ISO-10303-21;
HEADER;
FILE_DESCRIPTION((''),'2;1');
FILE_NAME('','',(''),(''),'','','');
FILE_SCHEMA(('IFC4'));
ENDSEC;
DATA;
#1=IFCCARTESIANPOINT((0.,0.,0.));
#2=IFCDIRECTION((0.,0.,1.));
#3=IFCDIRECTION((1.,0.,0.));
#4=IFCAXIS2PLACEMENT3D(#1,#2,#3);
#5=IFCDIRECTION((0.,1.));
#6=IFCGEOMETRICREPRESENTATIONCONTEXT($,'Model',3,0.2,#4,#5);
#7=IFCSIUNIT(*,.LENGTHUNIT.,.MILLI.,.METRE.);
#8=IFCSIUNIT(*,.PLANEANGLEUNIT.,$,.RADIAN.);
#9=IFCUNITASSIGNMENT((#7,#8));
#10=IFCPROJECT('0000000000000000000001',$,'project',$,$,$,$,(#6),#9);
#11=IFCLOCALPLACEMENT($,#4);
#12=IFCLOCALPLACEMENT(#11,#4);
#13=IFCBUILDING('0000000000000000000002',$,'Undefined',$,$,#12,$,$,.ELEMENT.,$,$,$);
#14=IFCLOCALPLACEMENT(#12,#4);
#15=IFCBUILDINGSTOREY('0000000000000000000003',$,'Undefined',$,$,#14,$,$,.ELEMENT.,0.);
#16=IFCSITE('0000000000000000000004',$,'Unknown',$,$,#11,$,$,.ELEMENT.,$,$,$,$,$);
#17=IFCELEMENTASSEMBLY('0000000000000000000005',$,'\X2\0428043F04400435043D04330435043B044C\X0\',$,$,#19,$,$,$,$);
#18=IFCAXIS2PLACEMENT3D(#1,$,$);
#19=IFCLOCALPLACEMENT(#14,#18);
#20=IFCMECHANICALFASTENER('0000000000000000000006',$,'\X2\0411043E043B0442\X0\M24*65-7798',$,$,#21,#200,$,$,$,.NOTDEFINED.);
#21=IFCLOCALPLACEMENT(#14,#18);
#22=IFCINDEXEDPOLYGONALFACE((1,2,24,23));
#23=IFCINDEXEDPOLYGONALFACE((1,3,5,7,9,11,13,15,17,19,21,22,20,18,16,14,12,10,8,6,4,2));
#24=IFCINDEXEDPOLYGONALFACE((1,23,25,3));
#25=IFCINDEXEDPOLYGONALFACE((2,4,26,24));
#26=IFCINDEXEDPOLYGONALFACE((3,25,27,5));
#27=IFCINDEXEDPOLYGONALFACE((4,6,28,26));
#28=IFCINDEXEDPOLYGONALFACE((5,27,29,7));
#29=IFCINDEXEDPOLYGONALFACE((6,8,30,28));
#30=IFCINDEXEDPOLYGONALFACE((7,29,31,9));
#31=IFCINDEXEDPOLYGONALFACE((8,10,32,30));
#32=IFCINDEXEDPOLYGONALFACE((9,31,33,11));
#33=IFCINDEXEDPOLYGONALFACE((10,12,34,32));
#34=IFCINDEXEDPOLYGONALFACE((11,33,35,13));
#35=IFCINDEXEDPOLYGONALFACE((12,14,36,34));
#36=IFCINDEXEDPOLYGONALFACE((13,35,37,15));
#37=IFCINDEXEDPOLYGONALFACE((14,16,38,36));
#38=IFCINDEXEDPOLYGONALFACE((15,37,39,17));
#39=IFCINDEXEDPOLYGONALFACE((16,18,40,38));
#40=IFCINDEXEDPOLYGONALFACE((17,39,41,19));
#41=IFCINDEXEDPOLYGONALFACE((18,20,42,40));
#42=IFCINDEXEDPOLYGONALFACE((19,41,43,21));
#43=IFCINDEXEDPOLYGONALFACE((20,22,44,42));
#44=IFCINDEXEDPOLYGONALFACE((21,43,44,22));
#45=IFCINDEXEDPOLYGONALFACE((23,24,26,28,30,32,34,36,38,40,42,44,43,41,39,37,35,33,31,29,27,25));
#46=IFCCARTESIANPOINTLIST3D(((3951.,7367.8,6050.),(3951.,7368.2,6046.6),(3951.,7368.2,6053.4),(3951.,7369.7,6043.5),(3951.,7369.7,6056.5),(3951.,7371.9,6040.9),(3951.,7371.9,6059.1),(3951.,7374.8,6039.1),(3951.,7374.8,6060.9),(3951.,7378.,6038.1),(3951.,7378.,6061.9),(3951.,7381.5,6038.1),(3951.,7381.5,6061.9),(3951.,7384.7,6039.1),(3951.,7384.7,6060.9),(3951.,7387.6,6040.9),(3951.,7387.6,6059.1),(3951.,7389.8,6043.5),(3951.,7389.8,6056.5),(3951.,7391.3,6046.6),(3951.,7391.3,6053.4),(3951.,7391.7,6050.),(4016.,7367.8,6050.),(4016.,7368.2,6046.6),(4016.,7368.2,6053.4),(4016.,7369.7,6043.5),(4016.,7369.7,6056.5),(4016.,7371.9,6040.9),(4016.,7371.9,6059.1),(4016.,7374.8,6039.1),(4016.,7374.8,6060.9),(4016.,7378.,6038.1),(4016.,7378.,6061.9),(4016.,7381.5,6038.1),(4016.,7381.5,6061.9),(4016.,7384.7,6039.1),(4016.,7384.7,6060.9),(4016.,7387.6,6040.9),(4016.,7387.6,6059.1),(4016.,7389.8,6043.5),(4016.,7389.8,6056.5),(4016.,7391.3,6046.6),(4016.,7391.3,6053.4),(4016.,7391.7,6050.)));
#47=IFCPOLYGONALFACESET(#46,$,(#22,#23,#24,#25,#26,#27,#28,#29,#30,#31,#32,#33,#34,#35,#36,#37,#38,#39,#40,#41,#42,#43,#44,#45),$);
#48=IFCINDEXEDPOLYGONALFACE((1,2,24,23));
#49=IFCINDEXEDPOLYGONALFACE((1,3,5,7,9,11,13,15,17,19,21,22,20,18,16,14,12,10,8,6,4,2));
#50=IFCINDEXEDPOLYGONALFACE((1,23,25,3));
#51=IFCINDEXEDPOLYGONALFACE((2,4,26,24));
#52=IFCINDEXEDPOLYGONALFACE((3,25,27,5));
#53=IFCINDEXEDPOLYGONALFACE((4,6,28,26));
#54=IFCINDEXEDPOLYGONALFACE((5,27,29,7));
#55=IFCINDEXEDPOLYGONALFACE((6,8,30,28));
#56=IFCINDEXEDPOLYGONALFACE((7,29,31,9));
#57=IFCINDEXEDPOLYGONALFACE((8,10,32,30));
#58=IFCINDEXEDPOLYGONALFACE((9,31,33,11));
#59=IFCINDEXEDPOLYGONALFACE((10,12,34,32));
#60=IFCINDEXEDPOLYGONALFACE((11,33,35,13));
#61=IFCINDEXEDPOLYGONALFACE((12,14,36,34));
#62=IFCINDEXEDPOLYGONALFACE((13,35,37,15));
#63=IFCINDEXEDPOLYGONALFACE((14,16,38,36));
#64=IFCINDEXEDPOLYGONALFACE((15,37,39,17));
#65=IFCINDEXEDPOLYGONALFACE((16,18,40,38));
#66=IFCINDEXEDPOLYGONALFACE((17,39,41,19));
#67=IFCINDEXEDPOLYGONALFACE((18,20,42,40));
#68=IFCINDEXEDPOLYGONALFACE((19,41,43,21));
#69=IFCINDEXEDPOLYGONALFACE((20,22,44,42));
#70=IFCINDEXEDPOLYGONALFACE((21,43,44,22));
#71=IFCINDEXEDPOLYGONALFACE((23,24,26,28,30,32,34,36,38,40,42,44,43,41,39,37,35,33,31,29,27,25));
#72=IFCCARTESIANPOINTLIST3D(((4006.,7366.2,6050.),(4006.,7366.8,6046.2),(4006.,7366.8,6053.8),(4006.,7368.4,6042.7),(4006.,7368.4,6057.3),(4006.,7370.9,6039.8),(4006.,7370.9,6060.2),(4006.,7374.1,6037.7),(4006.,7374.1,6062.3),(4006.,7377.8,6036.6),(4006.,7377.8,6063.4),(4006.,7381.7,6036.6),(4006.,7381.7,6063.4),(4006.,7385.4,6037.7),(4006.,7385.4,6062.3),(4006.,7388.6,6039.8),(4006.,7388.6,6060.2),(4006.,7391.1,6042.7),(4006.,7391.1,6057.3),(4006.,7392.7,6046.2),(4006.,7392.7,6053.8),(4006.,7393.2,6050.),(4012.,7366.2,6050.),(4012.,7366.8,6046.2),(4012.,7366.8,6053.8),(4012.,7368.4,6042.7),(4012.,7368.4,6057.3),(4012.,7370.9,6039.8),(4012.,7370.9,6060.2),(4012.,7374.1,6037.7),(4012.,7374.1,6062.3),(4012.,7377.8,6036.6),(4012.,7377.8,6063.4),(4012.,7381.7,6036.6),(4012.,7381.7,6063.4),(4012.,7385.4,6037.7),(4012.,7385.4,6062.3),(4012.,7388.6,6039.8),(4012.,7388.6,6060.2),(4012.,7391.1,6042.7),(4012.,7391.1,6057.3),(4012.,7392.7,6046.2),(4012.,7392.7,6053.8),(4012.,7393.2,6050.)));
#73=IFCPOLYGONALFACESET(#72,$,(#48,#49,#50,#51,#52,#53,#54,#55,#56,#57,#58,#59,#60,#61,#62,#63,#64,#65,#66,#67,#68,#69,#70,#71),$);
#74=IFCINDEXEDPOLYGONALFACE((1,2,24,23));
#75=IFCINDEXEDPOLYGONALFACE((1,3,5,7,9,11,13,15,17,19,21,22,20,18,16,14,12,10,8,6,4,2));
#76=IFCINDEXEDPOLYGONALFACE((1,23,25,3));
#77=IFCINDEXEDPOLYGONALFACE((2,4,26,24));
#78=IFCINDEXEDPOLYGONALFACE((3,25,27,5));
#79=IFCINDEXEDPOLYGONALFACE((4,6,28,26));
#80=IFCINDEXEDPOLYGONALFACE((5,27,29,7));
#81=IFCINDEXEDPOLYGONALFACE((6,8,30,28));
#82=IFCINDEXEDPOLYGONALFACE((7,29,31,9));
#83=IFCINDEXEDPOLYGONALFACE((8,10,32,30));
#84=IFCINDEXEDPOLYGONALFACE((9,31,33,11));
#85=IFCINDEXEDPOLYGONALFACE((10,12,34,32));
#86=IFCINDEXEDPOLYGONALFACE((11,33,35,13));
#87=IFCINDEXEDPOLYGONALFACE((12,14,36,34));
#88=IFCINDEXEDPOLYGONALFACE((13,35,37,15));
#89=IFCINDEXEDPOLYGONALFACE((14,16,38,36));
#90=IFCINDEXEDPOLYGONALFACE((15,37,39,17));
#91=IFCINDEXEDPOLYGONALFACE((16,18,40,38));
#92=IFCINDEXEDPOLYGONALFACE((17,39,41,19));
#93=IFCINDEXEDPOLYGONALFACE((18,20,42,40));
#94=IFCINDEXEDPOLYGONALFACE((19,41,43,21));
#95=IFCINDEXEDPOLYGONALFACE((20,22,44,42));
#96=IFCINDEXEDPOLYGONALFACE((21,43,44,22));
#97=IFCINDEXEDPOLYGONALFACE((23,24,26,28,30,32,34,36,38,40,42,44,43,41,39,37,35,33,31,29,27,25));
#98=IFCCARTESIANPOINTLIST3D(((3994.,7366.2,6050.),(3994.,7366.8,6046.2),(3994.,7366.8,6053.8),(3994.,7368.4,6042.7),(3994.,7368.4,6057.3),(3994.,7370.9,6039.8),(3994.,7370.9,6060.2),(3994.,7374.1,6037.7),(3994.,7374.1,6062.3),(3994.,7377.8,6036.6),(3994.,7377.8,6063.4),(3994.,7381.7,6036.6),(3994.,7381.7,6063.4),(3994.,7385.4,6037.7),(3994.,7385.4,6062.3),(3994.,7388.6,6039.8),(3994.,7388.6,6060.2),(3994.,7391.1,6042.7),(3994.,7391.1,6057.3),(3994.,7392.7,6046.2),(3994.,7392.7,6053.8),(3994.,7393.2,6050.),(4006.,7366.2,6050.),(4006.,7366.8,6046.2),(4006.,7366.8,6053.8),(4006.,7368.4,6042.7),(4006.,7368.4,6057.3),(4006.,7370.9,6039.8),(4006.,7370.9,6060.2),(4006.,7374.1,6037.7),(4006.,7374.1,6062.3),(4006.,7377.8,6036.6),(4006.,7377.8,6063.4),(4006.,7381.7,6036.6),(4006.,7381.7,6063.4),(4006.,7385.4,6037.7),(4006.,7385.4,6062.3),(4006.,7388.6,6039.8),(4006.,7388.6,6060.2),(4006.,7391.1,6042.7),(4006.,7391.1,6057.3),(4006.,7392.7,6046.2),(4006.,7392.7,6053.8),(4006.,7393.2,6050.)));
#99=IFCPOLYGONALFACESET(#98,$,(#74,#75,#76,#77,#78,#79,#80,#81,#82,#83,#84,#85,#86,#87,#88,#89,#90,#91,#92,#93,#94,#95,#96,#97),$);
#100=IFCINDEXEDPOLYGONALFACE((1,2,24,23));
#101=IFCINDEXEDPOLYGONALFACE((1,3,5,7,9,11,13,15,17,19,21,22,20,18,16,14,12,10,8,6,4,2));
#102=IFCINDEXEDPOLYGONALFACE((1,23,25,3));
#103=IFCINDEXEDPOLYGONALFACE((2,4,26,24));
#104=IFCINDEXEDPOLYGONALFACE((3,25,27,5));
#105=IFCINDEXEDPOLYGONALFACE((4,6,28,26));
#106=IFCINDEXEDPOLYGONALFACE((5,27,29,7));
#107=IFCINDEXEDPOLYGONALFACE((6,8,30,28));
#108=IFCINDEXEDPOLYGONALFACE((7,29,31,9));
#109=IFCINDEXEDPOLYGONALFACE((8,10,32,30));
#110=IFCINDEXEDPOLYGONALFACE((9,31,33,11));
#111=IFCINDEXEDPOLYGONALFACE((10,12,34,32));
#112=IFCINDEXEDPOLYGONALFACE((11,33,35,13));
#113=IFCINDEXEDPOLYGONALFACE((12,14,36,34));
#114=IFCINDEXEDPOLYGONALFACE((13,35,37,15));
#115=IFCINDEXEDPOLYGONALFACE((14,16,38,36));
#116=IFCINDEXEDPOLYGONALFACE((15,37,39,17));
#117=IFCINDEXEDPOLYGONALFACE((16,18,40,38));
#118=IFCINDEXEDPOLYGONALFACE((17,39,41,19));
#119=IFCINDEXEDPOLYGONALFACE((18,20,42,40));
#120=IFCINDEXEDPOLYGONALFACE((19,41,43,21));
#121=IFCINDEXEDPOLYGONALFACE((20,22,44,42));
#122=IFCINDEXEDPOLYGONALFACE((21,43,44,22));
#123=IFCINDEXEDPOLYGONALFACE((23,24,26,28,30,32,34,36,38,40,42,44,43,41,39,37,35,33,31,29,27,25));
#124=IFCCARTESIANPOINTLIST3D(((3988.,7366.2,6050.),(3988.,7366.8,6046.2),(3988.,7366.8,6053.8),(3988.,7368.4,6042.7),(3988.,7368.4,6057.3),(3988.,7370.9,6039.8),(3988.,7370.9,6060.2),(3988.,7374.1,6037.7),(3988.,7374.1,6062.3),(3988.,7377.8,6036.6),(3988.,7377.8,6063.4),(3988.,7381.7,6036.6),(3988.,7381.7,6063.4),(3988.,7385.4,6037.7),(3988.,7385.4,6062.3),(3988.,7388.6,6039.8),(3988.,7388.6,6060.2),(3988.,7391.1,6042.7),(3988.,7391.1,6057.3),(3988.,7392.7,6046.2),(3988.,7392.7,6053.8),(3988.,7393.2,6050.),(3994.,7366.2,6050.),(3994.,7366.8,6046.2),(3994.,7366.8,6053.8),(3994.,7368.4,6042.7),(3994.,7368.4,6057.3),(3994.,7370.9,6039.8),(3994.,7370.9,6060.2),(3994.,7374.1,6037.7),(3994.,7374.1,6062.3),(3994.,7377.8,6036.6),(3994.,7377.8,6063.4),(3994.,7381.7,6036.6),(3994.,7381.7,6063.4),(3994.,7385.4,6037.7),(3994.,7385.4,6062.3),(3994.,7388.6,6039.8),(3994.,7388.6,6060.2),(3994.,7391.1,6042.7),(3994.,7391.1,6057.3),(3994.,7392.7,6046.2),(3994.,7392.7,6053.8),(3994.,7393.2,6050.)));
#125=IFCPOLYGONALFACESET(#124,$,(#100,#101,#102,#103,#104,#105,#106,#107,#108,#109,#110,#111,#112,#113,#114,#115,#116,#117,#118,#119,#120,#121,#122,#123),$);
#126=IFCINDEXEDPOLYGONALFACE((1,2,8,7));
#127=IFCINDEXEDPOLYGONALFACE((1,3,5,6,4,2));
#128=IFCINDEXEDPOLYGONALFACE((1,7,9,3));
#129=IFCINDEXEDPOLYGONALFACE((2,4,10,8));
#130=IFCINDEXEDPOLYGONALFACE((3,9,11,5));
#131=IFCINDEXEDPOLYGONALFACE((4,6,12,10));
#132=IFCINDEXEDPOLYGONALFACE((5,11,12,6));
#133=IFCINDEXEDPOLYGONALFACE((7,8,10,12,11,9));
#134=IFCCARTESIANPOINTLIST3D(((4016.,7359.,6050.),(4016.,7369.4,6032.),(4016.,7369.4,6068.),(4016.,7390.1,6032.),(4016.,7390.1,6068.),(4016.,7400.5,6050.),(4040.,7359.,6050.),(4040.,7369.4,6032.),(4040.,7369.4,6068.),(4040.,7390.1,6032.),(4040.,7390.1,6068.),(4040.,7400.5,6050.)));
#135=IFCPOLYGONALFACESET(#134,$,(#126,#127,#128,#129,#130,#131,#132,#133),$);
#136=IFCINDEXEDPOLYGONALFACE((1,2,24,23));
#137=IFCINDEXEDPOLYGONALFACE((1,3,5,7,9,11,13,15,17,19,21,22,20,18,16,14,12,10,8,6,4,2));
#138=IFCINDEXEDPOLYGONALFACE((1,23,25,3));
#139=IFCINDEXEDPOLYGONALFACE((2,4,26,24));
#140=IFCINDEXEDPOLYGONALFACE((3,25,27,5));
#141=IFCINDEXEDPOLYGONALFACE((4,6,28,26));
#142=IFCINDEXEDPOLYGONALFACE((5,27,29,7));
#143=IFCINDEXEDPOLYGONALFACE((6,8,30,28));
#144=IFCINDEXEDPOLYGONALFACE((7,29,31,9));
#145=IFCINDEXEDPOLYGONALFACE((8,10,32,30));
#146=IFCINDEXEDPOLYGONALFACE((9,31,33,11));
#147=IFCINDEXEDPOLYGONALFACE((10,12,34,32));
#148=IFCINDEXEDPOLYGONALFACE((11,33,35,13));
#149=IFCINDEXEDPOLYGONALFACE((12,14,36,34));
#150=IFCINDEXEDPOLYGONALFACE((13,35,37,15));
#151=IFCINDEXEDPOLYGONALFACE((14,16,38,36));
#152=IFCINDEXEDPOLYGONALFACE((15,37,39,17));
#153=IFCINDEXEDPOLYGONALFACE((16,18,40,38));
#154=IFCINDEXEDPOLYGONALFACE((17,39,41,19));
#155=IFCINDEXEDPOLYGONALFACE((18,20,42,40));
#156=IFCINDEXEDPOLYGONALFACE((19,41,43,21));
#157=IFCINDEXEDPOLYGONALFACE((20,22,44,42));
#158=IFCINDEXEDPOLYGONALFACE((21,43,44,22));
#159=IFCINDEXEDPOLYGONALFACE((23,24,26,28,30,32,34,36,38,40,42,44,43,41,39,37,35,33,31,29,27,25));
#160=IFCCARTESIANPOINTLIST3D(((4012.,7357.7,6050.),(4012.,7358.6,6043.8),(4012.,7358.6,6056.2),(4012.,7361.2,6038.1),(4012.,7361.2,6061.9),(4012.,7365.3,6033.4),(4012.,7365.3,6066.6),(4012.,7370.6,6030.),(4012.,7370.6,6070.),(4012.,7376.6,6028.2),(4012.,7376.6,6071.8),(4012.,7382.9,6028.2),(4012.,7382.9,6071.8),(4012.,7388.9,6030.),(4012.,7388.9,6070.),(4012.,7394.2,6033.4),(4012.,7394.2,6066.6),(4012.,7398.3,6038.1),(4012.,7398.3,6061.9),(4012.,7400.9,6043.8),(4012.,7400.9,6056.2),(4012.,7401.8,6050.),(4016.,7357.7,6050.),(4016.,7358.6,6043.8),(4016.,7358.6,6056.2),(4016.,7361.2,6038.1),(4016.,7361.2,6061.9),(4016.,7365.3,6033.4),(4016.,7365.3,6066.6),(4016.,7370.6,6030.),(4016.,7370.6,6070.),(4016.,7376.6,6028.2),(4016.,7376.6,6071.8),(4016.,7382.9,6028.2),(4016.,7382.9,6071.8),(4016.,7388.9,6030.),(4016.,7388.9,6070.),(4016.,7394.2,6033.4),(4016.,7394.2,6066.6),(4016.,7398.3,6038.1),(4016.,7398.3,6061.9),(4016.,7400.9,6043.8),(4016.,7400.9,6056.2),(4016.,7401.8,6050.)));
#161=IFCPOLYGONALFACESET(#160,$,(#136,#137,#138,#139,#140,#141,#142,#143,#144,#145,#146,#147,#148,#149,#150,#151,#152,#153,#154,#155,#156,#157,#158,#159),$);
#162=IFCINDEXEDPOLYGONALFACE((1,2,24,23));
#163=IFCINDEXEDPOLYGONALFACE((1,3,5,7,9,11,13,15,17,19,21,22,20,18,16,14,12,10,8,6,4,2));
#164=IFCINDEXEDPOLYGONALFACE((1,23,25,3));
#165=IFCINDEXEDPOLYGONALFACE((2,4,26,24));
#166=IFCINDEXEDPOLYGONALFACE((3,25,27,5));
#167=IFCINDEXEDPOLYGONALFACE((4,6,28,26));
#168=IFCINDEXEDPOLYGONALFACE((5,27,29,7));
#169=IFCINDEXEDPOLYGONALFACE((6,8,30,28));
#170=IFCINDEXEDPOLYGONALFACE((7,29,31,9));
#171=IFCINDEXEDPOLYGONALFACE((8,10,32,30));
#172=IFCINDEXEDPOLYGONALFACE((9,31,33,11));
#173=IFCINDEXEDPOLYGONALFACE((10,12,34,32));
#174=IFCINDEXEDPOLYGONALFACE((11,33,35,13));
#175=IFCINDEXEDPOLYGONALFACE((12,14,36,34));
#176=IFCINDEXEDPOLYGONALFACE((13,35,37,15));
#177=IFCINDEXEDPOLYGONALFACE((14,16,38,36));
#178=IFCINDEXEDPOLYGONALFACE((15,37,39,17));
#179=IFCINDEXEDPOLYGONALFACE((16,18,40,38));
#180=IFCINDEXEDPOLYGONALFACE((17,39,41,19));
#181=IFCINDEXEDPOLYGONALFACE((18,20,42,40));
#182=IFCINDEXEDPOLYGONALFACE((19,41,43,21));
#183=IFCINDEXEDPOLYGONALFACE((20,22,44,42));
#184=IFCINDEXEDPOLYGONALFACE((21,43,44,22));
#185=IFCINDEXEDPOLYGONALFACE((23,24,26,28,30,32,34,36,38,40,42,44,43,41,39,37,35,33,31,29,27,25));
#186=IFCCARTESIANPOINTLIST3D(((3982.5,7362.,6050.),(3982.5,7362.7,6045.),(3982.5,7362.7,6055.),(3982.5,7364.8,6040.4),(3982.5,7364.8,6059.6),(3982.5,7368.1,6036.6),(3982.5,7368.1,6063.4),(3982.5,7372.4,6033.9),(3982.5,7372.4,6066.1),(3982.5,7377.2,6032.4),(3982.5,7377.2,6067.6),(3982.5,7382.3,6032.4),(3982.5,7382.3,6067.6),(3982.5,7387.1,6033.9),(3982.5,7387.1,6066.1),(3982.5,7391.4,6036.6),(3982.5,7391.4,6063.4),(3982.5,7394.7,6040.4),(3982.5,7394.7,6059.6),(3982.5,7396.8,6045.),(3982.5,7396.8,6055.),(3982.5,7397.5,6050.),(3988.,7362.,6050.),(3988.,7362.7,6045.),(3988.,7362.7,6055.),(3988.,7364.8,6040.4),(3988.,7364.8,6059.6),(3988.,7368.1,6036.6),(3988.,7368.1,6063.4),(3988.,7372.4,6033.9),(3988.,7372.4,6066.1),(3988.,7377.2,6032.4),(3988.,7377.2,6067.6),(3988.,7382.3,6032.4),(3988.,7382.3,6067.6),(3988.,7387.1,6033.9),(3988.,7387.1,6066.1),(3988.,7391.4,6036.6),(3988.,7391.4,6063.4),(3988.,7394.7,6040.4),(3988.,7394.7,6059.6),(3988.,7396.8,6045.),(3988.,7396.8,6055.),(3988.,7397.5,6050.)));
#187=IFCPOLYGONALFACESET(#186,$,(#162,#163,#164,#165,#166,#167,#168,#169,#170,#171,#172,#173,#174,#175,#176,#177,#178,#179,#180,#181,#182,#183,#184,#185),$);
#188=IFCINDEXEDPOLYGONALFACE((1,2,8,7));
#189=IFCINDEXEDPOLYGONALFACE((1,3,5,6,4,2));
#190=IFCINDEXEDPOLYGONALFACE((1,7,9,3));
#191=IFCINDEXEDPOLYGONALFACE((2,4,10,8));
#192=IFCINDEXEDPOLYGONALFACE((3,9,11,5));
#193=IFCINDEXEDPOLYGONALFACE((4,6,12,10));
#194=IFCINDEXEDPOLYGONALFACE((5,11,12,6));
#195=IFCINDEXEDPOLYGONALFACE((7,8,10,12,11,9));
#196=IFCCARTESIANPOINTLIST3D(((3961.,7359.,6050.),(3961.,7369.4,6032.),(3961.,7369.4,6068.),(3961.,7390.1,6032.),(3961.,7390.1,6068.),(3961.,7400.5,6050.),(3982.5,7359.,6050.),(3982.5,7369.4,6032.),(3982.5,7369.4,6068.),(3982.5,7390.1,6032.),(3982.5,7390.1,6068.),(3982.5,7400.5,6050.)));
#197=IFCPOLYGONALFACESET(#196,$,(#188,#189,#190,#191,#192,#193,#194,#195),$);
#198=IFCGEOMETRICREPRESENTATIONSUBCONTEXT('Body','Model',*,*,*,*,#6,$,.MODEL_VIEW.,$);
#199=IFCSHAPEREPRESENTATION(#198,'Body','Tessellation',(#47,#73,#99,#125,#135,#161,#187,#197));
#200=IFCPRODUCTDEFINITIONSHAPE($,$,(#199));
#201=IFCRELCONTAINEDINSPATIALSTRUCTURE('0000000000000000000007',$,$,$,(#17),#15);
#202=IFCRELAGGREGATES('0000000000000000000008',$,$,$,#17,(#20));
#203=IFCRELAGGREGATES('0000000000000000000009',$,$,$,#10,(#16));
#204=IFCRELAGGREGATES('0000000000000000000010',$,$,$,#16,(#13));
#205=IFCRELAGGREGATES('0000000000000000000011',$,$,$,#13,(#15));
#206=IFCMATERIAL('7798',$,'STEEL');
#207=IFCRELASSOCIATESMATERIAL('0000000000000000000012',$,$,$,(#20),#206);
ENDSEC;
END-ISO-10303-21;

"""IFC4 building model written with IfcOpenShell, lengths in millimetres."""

from ifc_helpers import new_model, si_unit, direction, frame, origin_with_axes, place, context, subcontext, project, spatial, line, arc, indexed_curve, outline, extrude, source, transform, mapped, material, element, aggregate, save


model = new_model("IFC4")

# Units and contexts
model_context = context("Model", 3, precision=0.2, world=origin_with_axes(), true_north=direction((0.0, 1.0)))
body_context = subcontext(model_context, "Body", "Model", "MODEL_VIEW")
ifc_project = project(units=[si_unit("LENGTHUNIT", "METRE", prefix="MILLI"), si_unit("PLANEANGLEUNIT", "RADIAN")], contexts=[model_context])

# Site, building, storey
site_placement = place(None, origin_with_axes())
site = spatial("IfcSite", under=ifc_project, at=site_placement, Name="Unknown", CompositionType="ELEMENT")
building_placement = place(site_placement, origin_with_axes())
building = spatial("IfcBuilding", under=site, at=building_placement, Name="Undefined", CompositionType="ELEMENT")
storey_placement = place(building_placement, origin_with_axes())
storey = spatial("IfcBuildingStorey", under=building, at=storey_placement, Name="Undefined", CompositionType="ELEMENT", Elevation=0.0)

# Shared definitions
ifc_material_1 = material(Name="7798", Category="STEEL")

# Element assembly, mechanical fastener
assembly_1_placement = place(storey_placement, frame((3949.0, 5673.0, 6045.0), z_axis=(0.0, 0.0, 1.0), x_axis=(0.0, 1.0, 0.0)))
assembly_1 = element("IfcElementAssembly", 1, at=assembly_1_placement, inside=storey, Name="Шпренгель")
shared_shape_1 = source(origin_with_axes(), body_context, "Body", "SweptSolid", [
    extrude(outline(indexed_curve([(12.0, 0.0), (0.0, 12.0), (-12.0, 0.0), (0.0, -12.0)], segments=[arc(1, 2, 3), arc(3, 4, 1)])), frame((0.0, 0.0, 16.0), z_axis=(0.0, 0.0, -1.0), x_axis=(0.0, 1.0, 0.0)), (0.0, 0.0, 1.0), 65.0),
    extrude(outline(indexed_curve([(13.5, 0.0), (0.0, 13.5), (-13.5, 0.0), (0.0, -13.5)], segments=[arc(1, 2, 3), arc(3, 4, 1)])), frame((0.0, 0.0, 12.0), z_axis=(0.0, 0.0, -1.0), x_axis=(0.0, 1.0, 0.0)), (0.0, 0.0, 1.0), 6.0),
    extrude(outline(indexed_curve([(13.5, 0.0), (0.0, 13.5), (-13.5, 0.0), (0.0, -13.5)], segments=[arc(1, 2, 3), arc(3, 4, 1)])), frame((0.0, 0.0, 6.0), z_axis=(0.0, 0.0, -1.0), x_axis=(0.0, 1.0, 0.0)), (0.0, 0.0, 1.0), 12.0),
    extrude(outline(indexed_curve([(13.5, 0.0), (0.0, 13.5), (-13.5, 0.0), (0.0, -13.5)], segments=[arc(1, 2, 3), arc(3, 4, 1)])), frame((0.0, 0.0, -6.0), z_axis=(0.0, 0.0, -1.0), x_axis=(0.0, 1.0, 0.0)), (0.0, 0.0, 1.0), 6.0),
    extrude(outline(indexed_curve([(20.8, 0.0), (10.4, 18.0), (-10.4, 18.0), (-20.8, 0.0), (-10.4, -18.0), (10.4, -18.0)], segments=[line(1, 2, 3, 4, 5, 6, 1)])), frame((0.0, 0.0, 40.0), z_axis=(0.0, 0.0, -1.0), x_axis=(0.0, 1.0, 0.0)), (0.0, 0.0, 1.0), 24.0),
    extrude(outline(indexed_curve([(22.0, 0.0), (0.0, 22.0), (-22.0, 0.0), (0.0, -22.0)], segments=[arc(1, 2, 3), arc(3, 4, 1)])), frame((0.0, 0.0, 16.0), z_axis=(0.0, 0.0, -1.0), x_axis=(0.0, 1.0, 0.0)), (0.0, 0.0, 1.0), 4.0),
    extrude(outline(indexed_curve([(17.8, 0.0), (0.0, 17.8), (-17.8, 0.0), (0.0, -17.8)], segments=[arc(1, 2, 3), arc(3, 4, 1)])), frame((0.0, 0.0, -12.0), z_axis=(0.0, 0.0, -1.0), x_axis=(0.0, 1.0, 0.0)), (0.0, 0.0, 1.0), 5.5),
    extrude(outline(indexed_curve([(20.8, 0.0), (10.4, 18.0), (-10.4, 18.0), (-20.8, 0.0), (-10.4, -18.0), (10.4, -18.0)], segments=[line(1, 2, 3, 4, 5, 6, 1)])), frame((0.0, 0.0, -17.5), z_axis=(0.0, 0.0, -1.0), x_axis=(0.0, 1.0, 0.0)), (0.0, 0.0, 1.0), 21.5),
])
mechanical_fastener_1_placement = place(assembly_1_placement, frame((1706.8, -51.0, 5.0), z_axis=(0.0, -1.0, 0.0), x_axis=(0.0, 0.0, 1.0)))
mechanical_fastener_1 = element("IfcMechanicalFastener", 2, at=mechanical_fastener_1_placement, material=ifc_material_1, Name="БолтM24*65-7798", PredefinedType="NOTDEFINED", context=body_context, shape_type="MappedRepresentation", body=[
    mapped(shared_shape_1, transform((0.0, 0.0, 0.0))),
])
aggregate(assembly_1, [mechanical_fastener_1])

save(model, "model.ifc")
